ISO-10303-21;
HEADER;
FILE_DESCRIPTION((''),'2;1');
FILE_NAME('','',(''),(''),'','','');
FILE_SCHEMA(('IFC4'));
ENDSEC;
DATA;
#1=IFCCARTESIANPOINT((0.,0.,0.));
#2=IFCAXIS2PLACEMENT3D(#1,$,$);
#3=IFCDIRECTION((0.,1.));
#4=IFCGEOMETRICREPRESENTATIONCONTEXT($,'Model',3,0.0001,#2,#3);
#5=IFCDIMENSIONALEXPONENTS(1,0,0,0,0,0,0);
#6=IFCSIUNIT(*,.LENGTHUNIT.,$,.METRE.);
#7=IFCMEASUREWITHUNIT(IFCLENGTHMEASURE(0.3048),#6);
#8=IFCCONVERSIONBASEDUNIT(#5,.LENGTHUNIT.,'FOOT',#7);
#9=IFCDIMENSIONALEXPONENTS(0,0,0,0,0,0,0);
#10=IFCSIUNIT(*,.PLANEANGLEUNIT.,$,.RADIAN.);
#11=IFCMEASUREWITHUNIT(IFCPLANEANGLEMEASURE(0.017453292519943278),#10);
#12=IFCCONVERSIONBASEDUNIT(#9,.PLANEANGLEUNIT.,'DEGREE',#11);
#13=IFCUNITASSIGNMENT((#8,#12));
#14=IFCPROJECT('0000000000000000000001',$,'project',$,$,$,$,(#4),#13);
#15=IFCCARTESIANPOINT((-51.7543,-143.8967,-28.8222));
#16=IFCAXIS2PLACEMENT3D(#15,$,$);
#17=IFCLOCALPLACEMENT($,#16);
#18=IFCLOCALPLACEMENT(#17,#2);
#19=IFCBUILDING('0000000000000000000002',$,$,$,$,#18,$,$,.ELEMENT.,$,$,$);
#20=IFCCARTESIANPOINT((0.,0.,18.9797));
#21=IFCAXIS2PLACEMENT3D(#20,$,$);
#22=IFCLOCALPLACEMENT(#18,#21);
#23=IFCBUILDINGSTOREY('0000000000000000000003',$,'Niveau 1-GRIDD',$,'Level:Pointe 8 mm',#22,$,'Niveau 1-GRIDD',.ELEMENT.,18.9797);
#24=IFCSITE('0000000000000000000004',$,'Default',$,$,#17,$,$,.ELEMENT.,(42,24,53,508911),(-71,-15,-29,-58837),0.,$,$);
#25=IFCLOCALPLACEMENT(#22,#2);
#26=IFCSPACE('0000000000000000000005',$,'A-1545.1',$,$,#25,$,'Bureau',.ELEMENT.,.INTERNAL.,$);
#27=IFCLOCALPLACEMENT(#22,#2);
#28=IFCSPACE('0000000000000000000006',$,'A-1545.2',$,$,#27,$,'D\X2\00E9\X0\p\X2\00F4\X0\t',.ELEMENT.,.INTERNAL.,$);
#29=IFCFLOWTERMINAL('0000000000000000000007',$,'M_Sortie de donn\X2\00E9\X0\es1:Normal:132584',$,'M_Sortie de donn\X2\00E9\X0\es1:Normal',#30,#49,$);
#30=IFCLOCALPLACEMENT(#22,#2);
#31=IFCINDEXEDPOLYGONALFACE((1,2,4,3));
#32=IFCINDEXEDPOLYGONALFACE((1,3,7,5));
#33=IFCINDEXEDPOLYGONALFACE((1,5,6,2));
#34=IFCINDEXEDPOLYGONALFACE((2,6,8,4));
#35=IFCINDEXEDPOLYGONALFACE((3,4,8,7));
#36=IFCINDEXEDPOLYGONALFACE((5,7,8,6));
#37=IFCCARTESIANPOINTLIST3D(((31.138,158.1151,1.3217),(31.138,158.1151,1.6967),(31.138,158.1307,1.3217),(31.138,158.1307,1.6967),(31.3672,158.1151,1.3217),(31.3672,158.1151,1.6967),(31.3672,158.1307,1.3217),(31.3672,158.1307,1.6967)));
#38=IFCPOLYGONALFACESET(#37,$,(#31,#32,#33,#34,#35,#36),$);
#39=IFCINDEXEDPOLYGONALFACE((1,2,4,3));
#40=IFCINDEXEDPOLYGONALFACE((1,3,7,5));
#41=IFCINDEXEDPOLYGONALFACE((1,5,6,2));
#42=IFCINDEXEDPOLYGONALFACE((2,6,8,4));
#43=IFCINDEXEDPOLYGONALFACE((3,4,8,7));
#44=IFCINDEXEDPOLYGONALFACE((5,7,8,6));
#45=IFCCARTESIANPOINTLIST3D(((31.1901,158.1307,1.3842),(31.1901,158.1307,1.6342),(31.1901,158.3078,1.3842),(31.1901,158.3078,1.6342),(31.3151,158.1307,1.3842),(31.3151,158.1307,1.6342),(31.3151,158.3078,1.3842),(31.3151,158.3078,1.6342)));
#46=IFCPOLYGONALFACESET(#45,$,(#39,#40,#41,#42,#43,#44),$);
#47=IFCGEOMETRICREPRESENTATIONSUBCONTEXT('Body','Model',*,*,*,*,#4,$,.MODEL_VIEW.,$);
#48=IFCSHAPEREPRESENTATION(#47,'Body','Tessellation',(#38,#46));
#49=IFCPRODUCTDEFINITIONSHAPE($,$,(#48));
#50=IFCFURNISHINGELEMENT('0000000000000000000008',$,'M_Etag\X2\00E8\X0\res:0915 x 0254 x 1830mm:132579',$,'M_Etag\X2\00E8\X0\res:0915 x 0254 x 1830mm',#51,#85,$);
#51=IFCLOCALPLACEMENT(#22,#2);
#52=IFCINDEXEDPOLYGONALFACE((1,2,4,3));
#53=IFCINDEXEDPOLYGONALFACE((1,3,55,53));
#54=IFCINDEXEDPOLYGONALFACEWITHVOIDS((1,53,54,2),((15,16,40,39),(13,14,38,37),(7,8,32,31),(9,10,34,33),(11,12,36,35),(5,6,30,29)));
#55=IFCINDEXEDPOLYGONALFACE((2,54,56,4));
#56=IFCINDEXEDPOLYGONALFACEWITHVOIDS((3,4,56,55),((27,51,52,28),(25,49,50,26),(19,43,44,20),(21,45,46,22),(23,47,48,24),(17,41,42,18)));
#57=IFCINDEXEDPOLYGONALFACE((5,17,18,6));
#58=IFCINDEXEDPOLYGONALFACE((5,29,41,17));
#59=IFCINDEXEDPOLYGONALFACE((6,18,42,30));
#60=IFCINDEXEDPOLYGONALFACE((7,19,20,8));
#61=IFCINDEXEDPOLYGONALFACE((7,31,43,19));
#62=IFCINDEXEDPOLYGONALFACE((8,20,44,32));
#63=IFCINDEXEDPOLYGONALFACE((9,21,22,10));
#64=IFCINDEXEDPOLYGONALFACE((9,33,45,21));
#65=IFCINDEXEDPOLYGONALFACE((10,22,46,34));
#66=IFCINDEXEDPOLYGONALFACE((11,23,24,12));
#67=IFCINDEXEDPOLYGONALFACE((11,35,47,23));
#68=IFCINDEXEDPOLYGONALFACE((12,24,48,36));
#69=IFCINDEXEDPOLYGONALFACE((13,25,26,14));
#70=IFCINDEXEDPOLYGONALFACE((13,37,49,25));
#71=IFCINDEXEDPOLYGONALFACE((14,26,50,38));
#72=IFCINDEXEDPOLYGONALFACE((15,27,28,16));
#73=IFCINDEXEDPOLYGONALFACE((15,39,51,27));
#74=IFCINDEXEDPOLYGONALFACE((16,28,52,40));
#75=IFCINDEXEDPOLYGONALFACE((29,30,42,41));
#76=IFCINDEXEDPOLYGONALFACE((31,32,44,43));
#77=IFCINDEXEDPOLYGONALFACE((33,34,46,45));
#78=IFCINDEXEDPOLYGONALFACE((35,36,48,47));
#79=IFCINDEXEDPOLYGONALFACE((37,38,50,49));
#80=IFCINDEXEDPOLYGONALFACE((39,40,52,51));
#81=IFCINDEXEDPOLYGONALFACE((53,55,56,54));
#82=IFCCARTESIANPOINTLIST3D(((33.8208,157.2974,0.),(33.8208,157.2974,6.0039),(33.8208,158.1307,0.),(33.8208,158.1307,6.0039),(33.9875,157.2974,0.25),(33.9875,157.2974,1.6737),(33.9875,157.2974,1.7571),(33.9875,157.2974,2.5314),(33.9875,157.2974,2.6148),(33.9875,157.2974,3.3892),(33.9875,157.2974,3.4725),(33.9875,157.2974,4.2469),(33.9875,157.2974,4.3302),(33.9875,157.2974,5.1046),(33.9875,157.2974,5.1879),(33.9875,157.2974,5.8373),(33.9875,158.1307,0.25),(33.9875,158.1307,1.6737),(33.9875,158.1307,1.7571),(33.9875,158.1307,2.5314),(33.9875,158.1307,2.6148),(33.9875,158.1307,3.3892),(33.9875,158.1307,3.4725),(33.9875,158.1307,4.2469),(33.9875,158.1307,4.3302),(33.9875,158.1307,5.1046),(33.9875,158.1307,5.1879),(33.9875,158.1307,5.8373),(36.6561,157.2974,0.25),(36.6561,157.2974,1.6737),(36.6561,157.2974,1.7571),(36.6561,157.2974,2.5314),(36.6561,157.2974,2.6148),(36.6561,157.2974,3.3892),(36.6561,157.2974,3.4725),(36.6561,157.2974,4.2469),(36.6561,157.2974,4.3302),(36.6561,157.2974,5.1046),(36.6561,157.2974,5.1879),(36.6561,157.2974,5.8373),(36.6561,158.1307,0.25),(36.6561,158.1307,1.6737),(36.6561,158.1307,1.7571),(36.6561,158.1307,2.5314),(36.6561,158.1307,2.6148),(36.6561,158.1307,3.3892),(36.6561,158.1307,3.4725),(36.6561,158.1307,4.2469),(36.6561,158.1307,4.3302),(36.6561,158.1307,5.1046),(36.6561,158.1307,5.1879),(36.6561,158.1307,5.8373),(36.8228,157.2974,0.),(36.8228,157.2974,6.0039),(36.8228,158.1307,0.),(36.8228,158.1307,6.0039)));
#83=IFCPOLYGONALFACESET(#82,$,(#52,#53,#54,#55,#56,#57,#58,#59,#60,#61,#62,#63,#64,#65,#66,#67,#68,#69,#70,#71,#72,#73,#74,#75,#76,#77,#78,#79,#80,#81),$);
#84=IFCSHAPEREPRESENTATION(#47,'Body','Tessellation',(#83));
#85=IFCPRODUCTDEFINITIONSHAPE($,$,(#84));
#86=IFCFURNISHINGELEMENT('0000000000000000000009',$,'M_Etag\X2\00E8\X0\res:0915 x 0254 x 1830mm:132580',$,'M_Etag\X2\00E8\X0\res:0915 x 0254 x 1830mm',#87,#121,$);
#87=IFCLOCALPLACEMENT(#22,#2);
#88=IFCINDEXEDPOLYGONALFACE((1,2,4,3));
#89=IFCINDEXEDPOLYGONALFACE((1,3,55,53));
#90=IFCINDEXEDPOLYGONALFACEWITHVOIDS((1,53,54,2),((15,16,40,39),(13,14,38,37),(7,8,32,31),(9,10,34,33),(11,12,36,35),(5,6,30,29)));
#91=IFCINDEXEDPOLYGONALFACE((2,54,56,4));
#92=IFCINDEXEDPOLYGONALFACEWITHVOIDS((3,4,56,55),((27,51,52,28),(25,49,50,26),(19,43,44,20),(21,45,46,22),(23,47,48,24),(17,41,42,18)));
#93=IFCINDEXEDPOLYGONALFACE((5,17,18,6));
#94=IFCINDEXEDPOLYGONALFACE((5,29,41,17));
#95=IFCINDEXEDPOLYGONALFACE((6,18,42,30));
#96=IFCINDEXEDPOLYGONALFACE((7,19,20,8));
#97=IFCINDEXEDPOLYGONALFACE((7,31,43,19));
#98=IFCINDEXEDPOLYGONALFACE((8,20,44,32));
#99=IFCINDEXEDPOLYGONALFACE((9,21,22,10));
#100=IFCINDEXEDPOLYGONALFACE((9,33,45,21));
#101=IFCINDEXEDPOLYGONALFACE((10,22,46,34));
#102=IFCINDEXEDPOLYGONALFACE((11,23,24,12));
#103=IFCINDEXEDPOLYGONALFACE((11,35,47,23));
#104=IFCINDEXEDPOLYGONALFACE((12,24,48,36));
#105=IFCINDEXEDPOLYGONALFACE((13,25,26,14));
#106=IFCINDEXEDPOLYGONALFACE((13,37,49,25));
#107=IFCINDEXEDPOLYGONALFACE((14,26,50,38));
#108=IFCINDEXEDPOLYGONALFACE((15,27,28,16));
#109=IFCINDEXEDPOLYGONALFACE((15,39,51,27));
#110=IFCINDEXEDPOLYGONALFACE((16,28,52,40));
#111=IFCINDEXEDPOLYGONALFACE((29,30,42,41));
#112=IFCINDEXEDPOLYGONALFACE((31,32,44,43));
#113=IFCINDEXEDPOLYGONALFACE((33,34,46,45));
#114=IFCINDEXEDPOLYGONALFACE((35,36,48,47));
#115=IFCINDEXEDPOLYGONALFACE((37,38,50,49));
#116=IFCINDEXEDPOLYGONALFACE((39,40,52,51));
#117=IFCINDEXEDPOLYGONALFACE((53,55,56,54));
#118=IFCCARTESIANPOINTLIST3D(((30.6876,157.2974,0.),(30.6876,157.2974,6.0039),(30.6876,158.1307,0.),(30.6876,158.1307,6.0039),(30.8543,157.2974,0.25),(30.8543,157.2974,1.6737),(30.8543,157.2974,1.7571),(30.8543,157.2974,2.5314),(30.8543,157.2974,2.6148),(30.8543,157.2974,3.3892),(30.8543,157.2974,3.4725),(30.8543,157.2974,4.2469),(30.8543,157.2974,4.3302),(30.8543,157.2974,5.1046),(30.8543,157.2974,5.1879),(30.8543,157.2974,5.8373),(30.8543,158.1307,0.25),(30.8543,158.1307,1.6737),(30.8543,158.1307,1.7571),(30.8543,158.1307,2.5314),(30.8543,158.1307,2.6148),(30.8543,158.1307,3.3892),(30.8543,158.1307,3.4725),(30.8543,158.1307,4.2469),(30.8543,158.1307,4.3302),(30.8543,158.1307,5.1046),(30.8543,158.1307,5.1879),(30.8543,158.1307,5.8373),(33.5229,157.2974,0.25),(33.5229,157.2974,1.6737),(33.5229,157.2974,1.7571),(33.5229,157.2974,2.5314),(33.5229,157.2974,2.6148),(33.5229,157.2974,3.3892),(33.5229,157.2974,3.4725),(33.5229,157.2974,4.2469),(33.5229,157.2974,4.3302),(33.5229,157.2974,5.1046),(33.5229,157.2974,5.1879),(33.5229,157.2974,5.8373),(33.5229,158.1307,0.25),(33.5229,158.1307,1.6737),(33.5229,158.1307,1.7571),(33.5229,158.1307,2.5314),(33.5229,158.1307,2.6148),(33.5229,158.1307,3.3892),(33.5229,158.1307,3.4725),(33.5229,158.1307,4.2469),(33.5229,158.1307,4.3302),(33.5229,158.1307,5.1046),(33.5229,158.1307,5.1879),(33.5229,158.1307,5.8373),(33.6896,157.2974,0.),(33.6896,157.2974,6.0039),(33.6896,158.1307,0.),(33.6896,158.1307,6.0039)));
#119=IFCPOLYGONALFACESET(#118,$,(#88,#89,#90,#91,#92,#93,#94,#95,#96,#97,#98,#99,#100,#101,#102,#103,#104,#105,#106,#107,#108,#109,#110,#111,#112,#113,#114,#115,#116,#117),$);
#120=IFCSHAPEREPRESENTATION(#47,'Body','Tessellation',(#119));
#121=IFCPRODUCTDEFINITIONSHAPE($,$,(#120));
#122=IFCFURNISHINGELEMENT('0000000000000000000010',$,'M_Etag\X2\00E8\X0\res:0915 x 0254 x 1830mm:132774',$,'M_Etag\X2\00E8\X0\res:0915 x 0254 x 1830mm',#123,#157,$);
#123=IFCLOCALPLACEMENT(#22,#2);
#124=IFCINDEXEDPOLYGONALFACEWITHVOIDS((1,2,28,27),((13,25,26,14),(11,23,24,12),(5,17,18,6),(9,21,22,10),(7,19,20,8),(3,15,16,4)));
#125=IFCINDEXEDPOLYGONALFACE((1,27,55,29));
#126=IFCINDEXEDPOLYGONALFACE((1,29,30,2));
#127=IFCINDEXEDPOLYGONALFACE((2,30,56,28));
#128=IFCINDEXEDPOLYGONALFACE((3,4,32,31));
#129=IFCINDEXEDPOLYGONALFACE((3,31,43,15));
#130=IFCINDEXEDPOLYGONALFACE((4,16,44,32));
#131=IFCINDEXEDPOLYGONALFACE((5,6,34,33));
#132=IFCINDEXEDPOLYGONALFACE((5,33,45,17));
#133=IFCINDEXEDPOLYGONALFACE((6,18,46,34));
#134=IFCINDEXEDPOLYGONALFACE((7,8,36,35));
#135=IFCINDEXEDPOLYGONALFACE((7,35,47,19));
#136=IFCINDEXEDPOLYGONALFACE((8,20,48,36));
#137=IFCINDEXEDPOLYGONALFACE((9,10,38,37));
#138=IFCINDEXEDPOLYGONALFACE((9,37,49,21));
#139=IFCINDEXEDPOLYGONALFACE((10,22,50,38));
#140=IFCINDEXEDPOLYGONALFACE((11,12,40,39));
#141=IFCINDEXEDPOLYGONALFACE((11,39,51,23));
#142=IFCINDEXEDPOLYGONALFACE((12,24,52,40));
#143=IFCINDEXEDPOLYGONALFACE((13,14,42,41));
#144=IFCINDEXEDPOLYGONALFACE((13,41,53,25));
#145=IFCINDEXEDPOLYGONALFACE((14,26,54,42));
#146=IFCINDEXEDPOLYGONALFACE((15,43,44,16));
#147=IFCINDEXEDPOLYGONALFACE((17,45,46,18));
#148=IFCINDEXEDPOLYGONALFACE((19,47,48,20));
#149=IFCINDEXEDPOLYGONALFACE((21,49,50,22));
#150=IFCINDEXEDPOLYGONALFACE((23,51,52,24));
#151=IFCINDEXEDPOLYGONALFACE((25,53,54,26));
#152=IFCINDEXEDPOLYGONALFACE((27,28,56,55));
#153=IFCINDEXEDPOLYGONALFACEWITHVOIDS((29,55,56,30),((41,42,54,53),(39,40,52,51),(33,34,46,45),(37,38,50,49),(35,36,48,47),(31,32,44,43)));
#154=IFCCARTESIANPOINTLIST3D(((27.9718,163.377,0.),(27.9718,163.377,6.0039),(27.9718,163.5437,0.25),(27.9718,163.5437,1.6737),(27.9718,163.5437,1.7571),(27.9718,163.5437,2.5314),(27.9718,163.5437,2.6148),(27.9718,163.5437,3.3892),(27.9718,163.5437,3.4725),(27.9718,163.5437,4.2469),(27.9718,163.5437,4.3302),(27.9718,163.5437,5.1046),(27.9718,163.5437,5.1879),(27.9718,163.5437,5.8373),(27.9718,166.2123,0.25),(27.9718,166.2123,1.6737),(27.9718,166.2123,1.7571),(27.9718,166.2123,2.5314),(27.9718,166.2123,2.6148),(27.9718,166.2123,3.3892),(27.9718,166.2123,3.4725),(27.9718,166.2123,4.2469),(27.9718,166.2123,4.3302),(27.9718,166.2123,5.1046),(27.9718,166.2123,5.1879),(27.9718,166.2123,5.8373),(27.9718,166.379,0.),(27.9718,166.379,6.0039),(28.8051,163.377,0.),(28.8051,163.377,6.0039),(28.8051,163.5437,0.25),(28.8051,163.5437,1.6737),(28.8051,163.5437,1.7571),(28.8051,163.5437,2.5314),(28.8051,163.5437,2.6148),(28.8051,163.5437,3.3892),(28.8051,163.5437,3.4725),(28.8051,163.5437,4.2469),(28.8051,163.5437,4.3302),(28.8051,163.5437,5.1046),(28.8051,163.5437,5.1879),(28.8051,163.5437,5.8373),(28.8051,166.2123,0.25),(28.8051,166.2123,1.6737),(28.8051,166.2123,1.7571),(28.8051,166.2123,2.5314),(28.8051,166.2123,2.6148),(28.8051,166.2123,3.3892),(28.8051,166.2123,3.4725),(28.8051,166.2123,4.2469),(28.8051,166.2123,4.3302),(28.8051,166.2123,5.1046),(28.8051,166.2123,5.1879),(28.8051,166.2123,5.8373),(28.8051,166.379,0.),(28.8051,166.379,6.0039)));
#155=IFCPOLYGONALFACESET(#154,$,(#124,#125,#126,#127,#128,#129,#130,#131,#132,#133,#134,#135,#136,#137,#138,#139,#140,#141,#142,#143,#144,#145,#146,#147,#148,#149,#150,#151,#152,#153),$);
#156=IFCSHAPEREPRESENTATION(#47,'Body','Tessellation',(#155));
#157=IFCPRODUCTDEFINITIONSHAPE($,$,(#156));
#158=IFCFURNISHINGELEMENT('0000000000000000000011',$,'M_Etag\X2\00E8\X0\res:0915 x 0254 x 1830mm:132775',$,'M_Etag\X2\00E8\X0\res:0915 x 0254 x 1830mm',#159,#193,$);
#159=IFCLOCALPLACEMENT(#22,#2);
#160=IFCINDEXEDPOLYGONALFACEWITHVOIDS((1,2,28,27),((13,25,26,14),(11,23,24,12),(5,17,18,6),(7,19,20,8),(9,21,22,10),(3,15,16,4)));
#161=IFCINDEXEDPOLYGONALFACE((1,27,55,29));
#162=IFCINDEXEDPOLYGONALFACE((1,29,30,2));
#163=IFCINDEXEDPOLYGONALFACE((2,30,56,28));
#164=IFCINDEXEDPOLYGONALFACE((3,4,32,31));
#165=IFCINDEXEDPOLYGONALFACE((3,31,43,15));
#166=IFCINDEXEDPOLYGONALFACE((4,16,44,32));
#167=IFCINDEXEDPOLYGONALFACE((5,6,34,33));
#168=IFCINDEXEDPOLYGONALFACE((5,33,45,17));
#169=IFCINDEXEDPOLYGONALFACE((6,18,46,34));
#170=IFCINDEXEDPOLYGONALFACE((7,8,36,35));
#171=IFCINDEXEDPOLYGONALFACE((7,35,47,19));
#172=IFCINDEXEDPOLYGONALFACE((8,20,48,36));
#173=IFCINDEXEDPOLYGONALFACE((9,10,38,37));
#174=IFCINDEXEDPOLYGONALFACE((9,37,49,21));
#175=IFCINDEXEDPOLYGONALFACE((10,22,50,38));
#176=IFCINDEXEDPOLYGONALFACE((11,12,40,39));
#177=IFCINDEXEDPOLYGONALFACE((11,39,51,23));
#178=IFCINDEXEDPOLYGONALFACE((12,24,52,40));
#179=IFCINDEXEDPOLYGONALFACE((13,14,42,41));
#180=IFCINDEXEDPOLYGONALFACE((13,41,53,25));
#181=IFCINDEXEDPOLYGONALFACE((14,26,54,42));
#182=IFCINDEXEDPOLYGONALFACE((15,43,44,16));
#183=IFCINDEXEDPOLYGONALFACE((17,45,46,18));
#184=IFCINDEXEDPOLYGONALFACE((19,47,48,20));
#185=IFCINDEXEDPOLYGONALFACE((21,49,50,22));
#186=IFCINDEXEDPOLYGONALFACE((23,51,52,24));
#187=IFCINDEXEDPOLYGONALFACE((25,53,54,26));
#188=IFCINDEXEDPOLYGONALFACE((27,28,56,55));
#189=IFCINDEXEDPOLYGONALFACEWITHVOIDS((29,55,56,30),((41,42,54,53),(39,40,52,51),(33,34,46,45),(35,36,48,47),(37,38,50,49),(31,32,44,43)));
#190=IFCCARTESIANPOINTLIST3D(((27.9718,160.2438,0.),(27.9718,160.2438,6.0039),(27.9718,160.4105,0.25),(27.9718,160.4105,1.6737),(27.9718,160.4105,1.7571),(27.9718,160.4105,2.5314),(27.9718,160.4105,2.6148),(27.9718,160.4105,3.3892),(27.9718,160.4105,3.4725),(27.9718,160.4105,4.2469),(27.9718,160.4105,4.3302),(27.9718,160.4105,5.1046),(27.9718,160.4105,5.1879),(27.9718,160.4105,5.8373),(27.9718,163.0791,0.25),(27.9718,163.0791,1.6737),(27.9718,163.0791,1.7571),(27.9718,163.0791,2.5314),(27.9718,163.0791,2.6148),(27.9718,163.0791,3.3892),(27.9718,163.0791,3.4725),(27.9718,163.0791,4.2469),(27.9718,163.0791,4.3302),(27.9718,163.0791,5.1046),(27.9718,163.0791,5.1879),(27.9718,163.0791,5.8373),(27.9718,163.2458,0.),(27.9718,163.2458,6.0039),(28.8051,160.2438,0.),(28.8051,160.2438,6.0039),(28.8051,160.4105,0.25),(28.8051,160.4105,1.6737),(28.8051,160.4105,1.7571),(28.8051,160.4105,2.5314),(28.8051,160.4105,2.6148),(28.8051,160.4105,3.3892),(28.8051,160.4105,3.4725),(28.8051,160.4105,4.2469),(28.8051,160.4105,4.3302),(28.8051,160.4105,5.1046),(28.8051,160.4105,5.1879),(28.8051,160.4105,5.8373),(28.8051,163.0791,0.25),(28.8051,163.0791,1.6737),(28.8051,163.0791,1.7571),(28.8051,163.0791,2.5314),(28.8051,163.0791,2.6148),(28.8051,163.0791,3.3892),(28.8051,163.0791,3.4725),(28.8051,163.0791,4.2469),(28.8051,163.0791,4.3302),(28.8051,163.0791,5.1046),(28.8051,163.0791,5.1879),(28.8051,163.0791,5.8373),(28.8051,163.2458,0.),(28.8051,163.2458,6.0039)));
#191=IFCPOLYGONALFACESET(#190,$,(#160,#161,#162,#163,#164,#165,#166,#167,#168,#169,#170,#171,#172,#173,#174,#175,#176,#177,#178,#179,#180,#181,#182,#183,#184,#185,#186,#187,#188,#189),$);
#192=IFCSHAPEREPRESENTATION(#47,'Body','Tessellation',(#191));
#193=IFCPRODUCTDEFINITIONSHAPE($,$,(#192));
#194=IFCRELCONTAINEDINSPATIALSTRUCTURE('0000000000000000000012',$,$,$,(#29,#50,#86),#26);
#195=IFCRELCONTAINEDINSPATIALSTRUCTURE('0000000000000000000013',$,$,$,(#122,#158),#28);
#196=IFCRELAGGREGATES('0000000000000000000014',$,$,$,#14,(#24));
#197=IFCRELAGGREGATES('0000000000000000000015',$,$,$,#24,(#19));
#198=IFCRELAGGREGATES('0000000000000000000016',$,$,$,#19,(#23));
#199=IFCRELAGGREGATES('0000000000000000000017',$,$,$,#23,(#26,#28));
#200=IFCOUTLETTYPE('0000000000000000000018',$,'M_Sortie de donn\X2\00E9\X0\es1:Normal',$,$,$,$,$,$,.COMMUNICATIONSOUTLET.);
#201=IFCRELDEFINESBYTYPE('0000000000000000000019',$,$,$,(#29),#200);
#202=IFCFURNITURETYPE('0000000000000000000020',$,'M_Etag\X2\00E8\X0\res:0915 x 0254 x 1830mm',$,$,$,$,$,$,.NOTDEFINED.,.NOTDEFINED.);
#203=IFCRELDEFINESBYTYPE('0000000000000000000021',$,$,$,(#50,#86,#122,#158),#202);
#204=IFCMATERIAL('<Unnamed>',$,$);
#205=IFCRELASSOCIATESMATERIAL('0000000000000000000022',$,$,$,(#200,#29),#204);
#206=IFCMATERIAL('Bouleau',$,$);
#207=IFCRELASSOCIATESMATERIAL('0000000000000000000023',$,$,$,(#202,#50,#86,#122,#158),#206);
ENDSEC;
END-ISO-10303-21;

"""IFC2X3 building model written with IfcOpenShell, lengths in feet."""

from ifc_helpers import new_model, entity, si_unit, converted_unit, direction, frame, frame_2d, origin, place, context, subcontext, project, spatial, polyline, rectangle, outline, extrude, source, transform, mapped, material, type_object, type_shapes, element, save


model = new_model("IFC2X3")

# Units and contexts
model_context = context("Model", 3, precision=0.0001, world=origin(), true_north=direction((0.0, 1.0)))
body_context = subcontext(model_context, "Body", "Model", "MODEL_VIEW")
ifc_project = project(units=[converted_unit("LENGTHUNIT", "FOOT", entity("IfcLengthMeasure", 0.3048), si_unit("LENGTHUNIT", "METRE"), dimensions=[1, 0, 0, 0, 0, 0, 0]), converted_unit("PLANEANGLEUNIT", "DEGREE", entity("IfcPlaneAngleMeasure", 0.017453292519943278), si_unit("PLANEANGLEUNIT", "RADIAN"), dimensions=[0, 0, 0, 0, 0, 0, 0])], contexts=[model_context])

# Site, building, storey
site_placement = place(None, frame((-51.7543, -143.8967, -28.8222)))
site = spatial("IfcSite", under=ifc_project, at=site_placement, Name="Default", CompositionType="ELEMENT", RefLatitude=(42, 24, 53, 508911), RefLongitude=(-71, -15, -29, -58837), RefElevation=0.0)
building_placement = place(site_placement, origin())
building = spatial("IfcBuilding", under=site, at=building_placement, CompositionType="ELEMENT")
storey_placement = place(building_placement, frame((0.0, 0.0, 18.9797)))
storey = spatial("IfcBuildingStorey", under=building, at=storey_placement, Name="Niveau 1-GRIDD", ObjectType="Level:Pointe 8 mm", LongName="Niveau 1-GRIDD", CompositionType="ELEMENT", Elevation=18.9797)

# Shared definitions
ifc_material_1 = material(Name="<Unnamed>")
outlet_type = type_object("IfcOutletType", Name="M_Sortie de données1:Normal", PredefinedType="COMMUNICATIONSOUTLET", material=ifc_material_1)
shared_shape_1 = source(origin(), body_context, "Body", "SweptSolid", [
    extrude(rectangle(XDim=0.2292, YDim=0.375, at=frame_2d((0.0, 0.0), x_axis=(1.0, 0.0))), frame((0.0, 0.0, 0.0), z_axis=(0.0, 0.0, 1.0), x_axis=(-1.0, 0.0, 0.0)), (0.0, 0.0, 1.0), 0.0156),
    extrude(rectangle(XDim=0.125, YDim=0.25, at=frame_2d((0.0, 0.0), x_axis=(1.0, 0.0))), frame((0.0, 0.0, -0.1771), z_axis=(0.0, 0.0, 1.0), x_axis=(-1.0, 0.0, 0.0)), (0.0, 0.0, 1.0), 0.1771),
])
type_shapes(outlet_type, [shared_shape_1])

# Shared definitions
space_1_placement = place(storey_placement, origin())
space_1 = spatial("IfcSpace", under=storey, at=space_1_placement, Name="A-1545.1", LongName="Bureau", CompositionType="ELEMENT", InteriorOrExteriorSpace="INTERNAL")

# Shared definitions
space_2_placement = place(storey_placement, origin())
space_2 = spatial("IfcSpace", under=storey, at=space_2_placement, Name="A-1545.2", LongName="Dépôt", CompositionType="ELEMENT", InteriorOrExteriorSpace="INTERNAL")

# Flow terminal
flow_terminal_1_placement = place(space_1_placement, frame((31.2526, 158.1307, 1.5092), z_axis=(0.0, -1.0, 0.0), x_axis=(1.0, 0.0, 0.0)))
element("IfcFlowTerminal", 1, at=flow_terminal_1_placement, inside=space_1, type_object=outlet_type, material=ifc_material_1, Name="M_Sortie de données1:Normal:132584", ObjectType="M_Sortie de données1:Normal", context=body_context, shape_type="MappedRepresentation", body=[
    mapped(shared_shape_1, transform((0.0, 0.0, 0.0), scale=1.0)),
])

# Furnishing elements
ifc_material_2 = material(Name="Bouleau")
furniture_type_1 = type_object("IfcFurnitureType", Name="M_Etagères:0915 x 0254 x 1830mm", AssemblyPlace="NOTDEFINED", material=ifc_material_2)
shared_shape_2 = source(origin(), body_context, "Body", "SweptSolid", [
    extrude(outline(polyline([(-1.501, -3.002), (1.501, -3.002), (1.501, 3.002), (-1.501, 3.002), (-1.501, -3.002)]), holes=[polyline([(-1.3343, 2.8353), (1.3343, 2.8353), (1.3343, 2.1859), (-1.3343, 2.1859), (-1.3343, 2.8353)]), polyline([(-1.3343, -2.752), (-1.3343, -1.3282), (1.3343, -1.3282), (1.3343, -2.752), (-1.3343, -2.752)]), polyline([(1.3343, 0.4705), (-1.3343, 0.4705), (-1.3343, 1.2449), (1.3343, 1.2449), (1.3343, 0.4705)]), polyline([(-1.3343, 2.1026), (1.3343, 2.1026), (1.3343, 1.3282), (-1.3343, 1.3282), (-1.3343, 2.1026)]), polyline([(-1.3343, 0.3872), (1.3343, 0.3872), (1.3343, -0.3872), (-1.3343, -0.3872), (-1.3343, 0.3872)]), polyline([(-1.3343, -0.4705), (1.3343, -0.4705), (1.3343, -1.2449), (-1.3343, -1.2449), (-1.3343, -0.4705)])]), frame((0.0, -1.4167, 3.002), z_axis=(0.0, 1.0, 0.0), x_axis=(-1.0, 0.0, 0.0)), (0.0, 0.0, 1.0), 0.8333),
])
type_shapes(furniture_type_1, [shared_shape_2])
for number, where, z_axis, x_axis, name in (
    (2, (35.3218, 156.7141, 0.0), (0.0, 0.0, 1.0), (-1.0, 0.0, 0.0), "M_Etagères:0915 x 0254 x 1830mm:132579"),
    (3, (32.1886, 156.7141, 0.0), (0.0, 0.0, 1.0), (-1.0, 0.0, 0.0), "M_Etagères:0915 x 0254 x 1830mm:132580"),
):
    element("IfcFurnishingElement", number, at=place(space_1_placement, frame(where, z_axis=z_axis, x_axis=x_axis)), inside=space_1, type_object=furniture_type_1, material=ifc_material_2, Name=name, ObjectType="M_Etagères:0915 x 0254 x 1830mm", context=body_context, shape_type="MappedRepresentation", body=[
        mapped(shared_shape_2, transform((0.0, 0.0, 0.0), scale=1.0)),
    ])
for number, where, z_axis, x_axis, name in (
    (4, (29.3885, 164.878, 0.0), (0.0, 0.0, 1.0), (0.0, -1.0, 0.0), "M_Etagères:0915 x 0254 x 1830mm:132774"),
    (5, (29.3885, 161.7448, 0.0), (0.0, 0.0, 1.0), (0.0, -1.0, 0.0), "M_Etagères:0915 x 0254 x 1830mm:132775"),
):
    element("IfcFurnishingElement", number, at=place(space_2_placement, frame(where, z_axis=z_axis, x_axis=x_axis)), inside=space_2, type_object=furniture_type_1, material=ifc_material_2, Name=name, ObjectType="M_Etagères:0915 x 0254 x 1830mm", context=body_context, shape_type="MappedRepresentation", body=[
        mapped(shared_shape_2, transform((0.0, 0.0, 0.0), scale=1.0)),
    ])

save(model, "model.ifc")
